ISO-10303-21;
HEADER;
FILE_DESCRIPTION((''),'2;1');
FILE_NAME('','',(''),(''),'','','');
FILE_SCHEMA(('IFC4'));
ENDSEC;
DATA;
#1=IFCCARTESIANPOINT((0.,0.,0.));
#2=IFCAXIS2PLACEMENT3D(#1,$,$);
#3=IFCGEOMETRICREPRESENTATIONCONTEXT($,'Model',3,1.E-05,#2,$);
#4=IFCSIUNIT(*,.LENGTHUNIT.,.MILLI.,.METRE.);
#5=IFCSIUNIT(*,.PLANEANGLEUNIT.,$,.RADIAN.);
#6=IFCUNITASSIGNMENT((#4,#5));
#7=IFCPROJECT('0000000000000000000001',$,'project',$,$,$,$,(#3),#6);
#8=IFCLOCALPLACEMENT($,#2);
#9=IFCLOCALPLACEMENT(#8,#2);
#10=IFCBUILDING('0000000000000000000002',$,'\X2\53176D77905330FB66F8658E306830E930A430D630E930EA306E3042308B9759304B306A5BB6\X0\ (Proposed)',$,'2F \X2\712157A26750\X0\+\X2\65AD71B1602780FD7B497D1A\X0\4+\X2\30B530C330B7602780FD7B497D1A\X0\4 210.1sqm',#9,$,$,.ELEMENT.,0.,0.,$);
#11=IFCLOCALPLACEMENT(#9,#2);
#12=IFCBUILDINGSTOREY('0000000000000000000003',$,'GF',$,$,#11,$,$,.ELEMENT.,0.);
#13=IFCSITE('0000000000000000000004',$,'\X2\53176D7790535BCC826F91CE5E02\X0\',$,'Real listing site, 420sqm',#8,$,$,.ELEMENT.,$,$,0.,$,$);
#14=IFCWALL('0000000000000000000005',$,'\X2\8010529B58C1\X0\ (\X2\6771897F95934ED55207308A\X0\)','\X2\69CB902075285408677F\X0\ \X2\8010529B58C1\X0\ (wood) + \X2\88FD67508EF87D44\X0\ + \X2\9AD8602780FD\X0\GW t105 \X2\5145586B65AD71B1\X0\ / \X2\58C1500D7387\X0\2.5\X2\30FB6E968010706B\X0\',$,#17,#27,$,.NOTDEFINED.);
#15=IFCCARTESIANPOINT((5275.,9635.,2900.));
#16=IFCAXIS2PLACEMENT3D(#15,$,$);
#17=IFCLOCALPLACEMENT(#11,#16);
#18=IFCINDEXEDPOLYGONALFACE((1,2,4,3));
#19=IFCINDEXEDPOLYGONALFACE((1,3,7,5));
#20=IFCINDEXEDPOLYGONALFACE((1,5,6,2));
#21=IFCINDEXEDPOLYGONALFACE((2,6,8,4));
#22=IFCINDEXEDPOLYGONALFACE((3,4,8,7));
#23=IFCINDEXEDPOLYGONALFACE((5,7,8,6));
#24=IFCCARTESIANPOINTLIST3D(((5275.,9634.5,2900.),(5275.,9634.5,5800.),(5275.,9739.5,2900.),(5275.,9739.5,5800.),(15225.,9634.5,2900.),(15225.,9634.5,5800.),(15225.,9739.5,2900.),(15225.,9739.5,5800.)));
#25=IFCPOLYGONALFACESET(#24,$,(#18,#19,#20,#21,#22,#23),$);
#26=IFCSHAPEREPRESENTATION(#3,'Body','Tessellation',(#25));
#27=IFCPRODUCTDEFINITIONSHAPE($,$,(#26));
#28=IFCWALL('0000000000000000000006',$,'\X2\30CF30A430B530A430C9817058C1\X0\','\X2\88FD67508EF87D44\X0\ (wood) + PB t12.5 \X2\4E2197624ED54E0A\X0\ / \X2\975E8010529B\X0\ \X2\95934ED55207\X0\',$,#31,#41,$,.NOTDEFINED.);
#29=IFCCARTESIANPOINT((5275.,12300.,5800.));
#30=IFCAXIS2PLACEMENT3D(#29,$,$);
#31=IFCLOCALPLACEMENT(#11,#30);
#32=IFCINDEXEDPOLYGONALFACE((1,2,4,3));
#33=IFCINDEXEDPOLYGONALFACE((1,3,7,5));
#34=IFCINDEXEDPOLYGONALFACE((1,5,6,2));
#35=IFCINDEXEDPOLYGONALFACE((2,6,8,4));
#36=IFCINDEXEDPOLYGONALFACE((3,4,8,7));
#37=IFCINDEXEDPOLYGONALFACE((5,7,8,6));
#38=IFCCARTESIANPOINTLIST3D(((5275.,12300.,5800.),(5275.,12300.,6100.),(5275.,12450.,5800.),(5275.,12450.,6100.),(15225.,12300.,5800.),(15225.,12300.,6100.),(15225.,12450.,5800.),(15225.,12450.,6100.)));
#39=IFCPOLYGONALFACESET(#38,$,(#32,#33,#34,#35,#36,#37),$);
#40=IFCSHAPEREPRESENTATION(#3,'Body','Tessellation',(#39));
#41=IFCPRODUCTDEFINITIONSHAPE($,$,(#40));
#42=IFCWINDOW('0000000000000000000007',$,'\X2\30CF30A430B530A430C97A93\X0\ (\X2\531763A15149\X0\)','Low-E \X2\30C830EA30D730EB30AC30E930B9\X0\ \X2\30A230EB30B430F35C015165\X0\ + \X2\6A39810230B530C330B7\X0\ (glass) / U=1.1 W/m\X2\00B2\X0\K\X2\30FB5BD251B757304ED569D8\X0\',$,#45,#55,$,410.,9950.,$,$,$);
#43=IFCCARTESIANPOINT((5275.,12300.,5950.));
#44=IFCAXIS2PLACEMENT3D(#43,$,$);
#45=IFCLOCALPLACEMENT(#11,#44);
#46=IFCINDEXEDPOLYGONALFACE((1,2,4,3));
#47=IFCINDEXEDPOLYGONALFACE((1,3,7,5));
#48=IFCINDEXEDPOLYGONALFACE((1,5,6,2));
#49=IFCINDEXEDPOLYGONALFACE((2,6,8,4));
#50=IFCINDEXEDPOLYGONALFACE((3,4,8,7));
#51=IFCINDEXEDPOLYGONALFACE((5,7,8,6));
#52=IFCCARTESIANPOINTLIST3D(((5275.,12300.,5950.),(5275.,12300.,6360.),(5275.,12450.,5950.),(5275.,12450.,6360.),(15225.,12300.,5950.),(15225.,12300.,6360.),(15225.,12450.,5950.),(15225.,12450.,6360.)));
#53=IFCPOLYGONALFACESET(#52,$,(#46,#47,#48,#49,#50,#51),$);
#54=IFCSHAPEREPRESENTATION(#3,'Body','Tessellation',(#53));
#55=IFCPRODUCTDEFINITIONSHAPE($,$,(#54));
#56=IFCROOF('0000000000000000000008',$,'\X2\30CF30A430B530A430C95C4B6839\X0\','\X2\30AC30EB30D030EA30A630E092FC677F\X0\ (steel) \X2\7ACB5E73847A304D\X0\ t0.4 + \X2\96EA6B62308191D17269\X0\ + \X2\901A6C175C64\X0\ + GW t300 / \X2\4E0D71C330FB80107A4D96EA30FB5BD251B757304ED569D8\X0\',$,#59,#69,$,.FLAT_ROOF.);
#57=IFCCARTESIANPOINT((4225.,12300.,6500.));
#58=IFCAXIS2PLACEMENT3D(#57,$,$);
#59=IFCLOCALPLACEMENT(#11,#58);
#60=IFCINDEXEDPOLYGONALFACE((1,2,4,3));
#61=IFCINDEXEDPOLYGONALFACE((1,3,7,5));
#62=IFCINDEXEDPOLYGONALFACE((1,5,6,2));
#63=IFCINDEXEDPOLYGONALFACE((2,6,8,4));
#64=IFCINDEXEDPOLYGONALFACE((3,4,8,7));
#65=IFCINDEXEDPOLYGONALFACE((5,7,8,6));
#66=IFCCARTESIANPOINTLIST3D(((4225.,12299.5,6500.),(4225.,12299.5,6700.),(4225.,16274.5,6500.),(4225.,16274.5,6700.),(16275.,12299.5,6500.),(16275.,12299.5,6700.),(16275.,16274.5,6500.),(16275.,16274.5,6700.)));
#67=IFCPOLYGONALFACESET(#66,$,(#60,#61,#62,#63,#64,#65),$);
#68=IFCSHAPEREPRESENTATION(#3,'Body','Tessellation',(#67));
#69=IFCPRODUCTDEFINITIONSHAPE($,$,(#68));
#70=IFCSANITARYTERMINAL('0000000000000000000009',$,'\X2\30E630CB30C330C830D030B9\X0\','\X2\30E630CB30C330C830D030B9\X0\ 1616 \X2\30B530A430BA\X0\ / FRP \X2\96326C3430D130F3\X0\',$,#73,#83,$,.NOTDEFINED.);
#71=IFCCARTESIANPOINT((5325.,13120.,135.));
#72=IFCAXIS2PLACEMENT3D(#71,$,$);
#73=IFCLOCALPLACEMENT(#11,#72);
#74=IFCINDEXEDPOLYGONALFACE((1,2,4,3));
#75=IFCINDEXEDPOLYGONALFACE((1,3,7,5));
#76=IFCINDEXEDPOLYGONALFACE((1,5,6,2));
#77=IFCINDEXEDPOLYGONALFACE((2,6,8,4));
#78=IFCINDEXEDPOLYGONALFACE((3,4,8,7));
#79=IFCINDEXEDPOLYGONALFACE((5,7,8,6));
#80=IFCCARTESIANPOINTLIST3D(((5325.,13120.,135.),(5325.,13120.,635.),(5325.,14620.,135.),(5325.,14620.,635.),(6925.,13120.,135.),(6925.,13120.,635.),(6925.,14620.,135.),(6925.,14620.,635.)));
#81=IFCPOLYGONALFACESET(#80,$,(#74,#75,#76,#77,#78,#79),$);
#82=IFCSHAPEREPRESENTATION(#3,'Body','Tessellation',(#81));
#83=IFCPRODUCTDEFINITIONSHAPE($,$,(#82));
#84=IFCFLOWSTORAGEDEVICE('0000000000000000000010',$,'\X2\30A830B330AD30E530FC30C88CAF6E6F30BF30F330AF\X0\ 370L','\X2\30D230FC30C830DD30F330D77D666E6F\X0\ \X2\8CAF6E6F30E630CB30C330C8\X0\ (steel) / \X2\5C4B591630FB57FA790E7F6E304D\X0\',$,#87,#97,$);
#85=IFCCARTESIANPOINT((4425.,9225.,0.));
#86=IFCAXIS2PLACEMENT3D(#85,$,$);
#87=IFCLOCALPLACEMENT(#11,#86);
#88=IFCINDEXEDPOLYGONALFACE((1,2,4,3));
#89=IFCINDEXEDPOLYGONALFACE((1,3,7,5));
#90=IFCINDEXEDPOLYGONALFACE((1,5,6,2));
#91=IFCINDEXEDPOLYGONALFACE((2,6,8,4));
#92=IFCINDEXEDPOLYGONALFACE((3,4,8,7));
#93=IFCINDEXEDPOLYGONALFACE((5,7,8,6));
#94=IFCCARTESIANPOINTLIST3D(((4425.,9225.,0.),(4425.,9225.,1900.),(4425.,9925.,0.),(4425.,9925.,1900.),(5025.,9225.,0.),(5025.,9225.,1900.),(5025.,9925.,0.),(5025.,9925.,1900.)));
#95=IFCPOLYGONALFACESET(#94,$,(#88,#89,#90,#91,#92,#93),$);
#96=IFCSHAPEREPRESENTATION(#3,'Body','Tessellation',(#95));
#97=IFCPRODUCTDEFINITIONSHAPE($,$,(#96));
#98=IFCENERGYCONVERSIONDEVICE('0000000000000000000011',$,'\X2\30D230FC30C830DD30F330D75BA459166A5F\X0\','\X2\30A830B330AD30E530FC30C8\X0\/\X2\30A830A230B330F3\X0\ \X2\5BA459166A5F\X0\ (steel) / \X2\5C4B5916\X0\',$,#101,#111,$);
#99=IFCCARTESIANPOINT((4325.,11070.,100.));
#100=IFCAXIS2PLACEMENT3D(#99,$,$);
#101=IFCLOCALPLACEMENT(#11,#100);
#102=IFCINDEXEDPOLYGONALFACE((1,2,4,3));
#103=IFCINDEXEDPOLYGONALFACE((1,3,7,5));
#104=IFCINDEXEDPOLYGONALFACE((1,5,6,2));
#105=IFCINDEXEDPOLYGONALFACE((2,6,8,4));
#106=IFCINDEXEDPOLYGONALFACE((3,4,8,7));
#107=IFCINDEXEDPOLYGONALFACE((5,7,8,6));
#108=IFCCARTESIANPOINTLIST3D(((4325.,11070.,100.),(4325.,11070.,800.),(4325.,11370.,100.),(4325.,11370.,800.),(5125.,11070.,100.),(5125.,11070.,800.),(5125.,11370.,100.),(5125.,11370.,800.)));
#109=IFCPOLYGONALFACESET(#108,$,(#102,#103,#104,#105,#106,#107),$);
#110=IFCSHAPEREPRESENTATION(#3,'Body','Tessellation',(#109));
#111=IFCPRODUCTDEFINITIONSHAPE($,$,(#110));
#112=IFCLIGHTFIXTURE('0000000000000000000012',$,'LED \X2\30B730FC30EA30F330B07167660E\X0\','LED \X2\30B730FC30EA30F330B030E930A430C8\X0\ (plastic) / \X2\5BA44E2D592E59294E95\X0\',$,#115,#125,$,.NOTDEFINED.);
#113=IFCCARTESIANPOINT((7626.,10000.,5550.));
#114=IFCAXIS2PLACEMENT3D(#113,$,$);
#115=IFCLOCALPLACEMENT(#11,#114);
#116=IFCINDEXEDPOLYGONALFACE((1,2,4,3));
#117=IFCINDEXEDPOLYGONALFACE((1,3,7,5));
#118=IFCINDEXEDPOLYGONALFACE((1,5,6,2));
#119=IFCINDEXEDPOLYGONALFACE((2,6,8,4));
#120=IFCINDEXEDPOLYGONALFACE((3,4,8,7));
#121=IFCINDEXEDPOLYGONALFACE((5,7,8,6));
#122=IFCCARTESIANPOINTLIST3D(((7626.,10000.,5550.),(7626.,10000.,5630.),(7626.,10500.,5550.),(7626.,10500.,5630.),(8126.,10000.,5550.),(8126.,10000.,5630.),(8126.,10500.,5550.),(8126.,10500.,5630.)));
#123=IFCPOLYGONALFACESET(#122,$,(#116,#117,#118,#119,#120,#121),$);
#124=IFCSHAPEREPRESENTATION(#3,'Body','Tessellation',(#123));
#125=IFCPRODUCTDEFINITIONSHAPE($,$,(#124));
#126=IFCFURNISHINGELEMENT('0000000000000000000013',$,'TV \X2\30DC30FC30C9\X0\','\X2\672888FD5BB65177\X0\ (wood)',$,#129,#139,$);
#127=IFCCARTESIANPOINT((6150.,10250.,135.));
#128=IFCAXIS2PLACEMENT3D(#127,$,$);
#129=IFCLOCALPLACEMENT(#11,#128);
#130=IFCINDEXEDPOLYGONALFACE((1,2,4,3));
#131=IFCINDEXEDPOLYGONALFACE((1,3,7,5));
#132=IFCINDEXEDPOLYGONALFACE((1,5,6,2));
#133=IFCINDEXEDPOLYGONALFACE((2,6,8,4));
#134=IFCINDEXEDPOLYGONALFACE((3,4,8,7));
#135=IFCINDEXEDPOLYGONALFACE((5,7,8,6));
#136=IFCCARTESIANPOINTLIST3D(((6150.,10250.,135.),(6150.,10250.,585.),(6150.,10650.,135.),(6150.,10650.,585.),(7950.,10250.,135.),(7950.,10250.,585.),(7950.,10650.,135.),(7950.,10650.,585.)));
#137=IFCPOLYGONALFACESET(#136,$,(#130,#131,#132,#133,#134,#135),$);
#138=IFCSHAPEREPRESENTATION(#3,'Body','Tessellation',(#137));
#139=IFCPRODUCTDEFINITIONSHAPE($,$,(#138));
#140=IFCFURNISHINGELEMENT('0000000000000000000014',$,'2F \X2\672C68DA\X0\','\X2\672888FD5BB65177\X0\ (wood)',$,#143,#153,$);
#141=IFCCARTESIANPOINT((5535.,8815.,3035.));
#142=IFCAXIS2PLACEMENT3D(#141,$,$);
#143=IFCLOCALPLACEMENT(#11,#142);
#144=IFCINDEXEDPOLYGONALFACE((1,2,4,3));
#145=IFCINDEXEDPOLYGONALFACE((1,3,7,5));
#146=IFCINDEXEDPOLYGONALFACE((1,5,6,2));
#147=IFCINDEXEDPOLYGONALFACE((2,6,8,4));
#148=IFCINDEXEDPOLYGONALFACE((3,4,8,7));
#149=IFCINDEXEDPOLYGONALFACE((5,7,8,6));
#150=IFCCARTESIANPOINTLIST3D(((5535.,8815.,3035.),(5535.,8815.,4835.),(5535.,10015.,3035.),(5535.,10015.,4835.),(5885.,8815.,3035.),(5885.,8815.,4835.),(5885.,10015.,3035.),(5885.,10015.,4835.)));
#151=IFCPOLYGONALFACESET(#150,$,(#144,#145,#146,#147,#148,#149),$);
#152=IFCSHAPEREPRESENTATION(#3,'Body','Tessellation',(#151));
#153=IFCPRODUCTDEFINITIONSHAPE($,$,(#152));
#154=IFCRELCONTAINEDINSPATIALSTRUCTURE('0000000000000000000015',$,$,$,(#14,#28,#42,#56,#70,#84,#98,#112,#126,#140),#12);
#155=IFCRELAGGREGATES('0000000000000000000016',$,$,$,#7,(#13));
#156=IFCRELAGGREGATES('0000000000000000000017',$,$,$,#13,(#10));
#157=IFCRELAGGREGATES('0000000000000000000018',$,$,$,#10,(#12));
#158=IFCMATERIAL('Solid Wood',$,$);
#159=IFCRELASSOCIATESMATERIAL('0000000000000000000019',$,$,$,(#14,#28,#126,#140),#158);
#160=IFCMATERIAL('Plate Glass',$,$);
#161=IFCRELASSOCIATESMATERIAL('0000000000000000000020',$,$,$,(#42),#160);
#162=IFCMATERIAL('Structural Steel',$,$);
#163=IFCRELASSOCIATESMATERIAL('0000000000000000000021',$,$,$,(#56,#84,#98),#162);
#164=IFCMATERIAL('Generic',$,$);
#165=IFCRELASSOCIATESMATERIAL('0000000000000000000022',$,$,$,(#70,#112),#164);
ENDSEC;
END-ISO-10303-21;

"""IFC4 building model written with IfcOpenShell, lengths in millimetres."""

from ifc_helpers import new_model, si_unit, frame, frame_2d, origin, place, context, project, spatial, rectangle, extrude, material, element, fill, save


model = new_model("IFC4")

# Units and contexts
model_context = context("Model", 3, precision=1e-05, world=origin())
ifc_project = project(units=[si_unit("LENGTHUNIT", "METRE", prefix="MILLI"), si_unit("PLANEANGLEUNIT", "RADIAN")], contexts=[model_context])

# Site, building, storey
site_placement = place(None, origin())
site = spatial("IfcSite", under=ifc_project, at=site_placement, Name="北海道富良野市", ObjectType="Real listing site, 420sqm", CompositionType="ELEMENT", RefElevation=0.0)
building_placement = place(site_placement, origin())
building = spatial("IfcBuilding", under=site, at=building_placement, Name="北海道・書斎とライブラリのある静かな家 (Proposed)", ObjectType="2F 無垢材+断熱性能等級4+サッシ性能等級4 210.1sqm", CompositionType="ELEMENT", ElevationOfRefHeight=0.0, ElevationOfTerrain=0.0)
storey_placement = place(building_placement, origin())
storey = spatial("IfcBuildingStorey", under=building, at=storey_placement, Name="GF", CompositionType="ELEMENT", Elevation=0.0)

# Shared definitions
ifc_material_1 = material(Name="Solid Wood")

# Wall
wall_1_placement = place(storey_placement, frame((5275.0, 9635.0, 2900.0)))
element("IfcWall", 1, at=wall_1_placement, inside=storey, material=ifc_material_1, Name="耐力壁 (東西間仕切り)", Description="構造用合板 耐力壁 (wood) + 製材軸組 + 高性能GW t105 充填断熱 / 壁倍率2.5・準耐火", PredefinedType="NOTDEFINED", context=model_context, shape_type="SweptSolid", body=[
    extrude(rectangle(XDim=9950.0, YDim=105.0, at=frame_2d((4975.0, 52.0))), frame((5275.0, 9635.0, 2900.0)), (0.0, 0.0, 1.0), 2900.0),
])

# Wall, opening, window
wall_2_placement = place(storey_placement, frame((5275.0, 12300.0, 5800.0)))
wall_2 = element("IfcWall", 2, at=wall_2_placement, inside=storey, material=ifc_material_1, Name="ハイサイド腰壁", Description="製材軸組 (wood) + PB t12.5 両面仕上 / 非耐力 間仕切", PredefinedType="NOTDEFINED", context=model_context, shape_type="SweptSolid", body=[
    extrude(rectangle(XDim=9950.0, YDim=150.0, at=frame_2d((4975.0, 75.0))), frame((5275.0, 12300.0, 5800.0)), (0.0, 0.0, 1.0), 700.0),
])
opening_1_placement = place(storey_placement, frame((5275.0, 12300.0, 5950.0)))
opening_1 = element("IfcOpeningElement", 3, at=opening_1_placement, cuts=wall_2, PredefinedType="NOTDEFINED", context=model_context, shape_type="SweptSolid", body=[
    extrude(rectangle(XDim=9950.0, YDim=150.0, at=frame_2d((4975.0, 75.0))), frame((5275.0, 12300.0, 5950.0)), (0.0, 0.0, 1.0), 410.0),
])
ifc_material_2 = material(Name="Plate Glass")
window_placement = place(storey_placement, frame((5275.0, 12300.0, 5950.0)))
window = element("IfcWindow", 4, at=window_placement, inside=storey, material=ifc_material_2, Name="ハイサイド窓 (北採光)", Description="Low-E トリプルガラス アルゴン封入 + 樹脂サッシ (glass) / U=1.1 W/m²K・寒冷地仕様", OverallHeight=410.0, OverallWidth=9950.0, context=model_context, shape_type="SweptSolid", body=[
    extrude(rectangle(XDim=9950.0, YDim=150.0, at=frame_2d((4975.0, 75.0))), frame((5275.0, 12300.0, 5950.0)), (0.0, 0.0, 1.0), 410.0),
])
fill(opening_1, window)

# Roof
ifc_material_3 = material(Name="Structural Steel")
roof_placement = place(storey_placement, frame((4225.0, 12300.0, 6500.0)))
element("IfcRoof", 5, at=roof_placement, inside=storey, material=ifc_material_3, Name="ハイサイド屋根", Description="ガルバリウム鋼板 (steel) 立平葺き t0.4 + 雪止め金物 + 通気層 + GW t300 / 不燃・耐積雪・寒冷地仕様", PredefinedType="FLAT_ROOF", context=model_context, shape_type="SweptSolid", body=[
    extrude(rectangle(XDim=12050.0, YDim=3975.0, at=frame_2d((6025.0, 1987.0))), frame((4225.0, 12300.0, 6500.0)), (0.0, 0.0, 1.0), 200.0),
])

# Sanitary terminal
ifc_material_4 = material(Name="Generic")
sanitary_terminal_placement = place(storey_placement, frame((5325.0, 13120.0, 135.0)))
element("IfcSanitaryTerminal", 6, at=sanitary_terminal_placement, inside=storey, material=ifc_material_4, Name="ユニットバス", Description="ユニットバス 1616 サイズ / FRP 防水パン", PredefinedType="NOTDEFINED", context=model_context, shape_type="SweptSolid", body=[
    extrude(rectangle(XDim=1600.0, YDim=1500.0, at=frame_2d((800.0, 750.0))), frame((5325.0, 13120.0, 135.0)), (0.0, 0.0, 1.0), 500.0),
])

# Flow storage device
flow_storage_device_placement = place(storey_placement, frame((4425.0, 9225.0, 0.0)))
element("IfcFlowStorageDevice", 7, at=flow_storage_device_placement, inside=storey, material=ifc_material_3, Name="エコキュート貯湯タンク 370L", Description="ヒートポンプ給湯 貯湯ユニット (steel) / 屋外・基礎置き", context=model_context, shape_type="SweptSolid", body=[
    extrude(rectangle(XDim=600.0, YDim=700.0, at=frame_2d((300.0, 350.0))), frame((4425.0, 9225.0, 0.0)), (0.0, 0.0, 1.0), 1900.0),
])

# Energy conversion device
energy_conversion_device_placement = place(storey_placement, frame((4325.0, 11070.0, 100.0)))
element("IfcEnergyConversionDevice", 8, at=energy_conversion_device_placement, inside=storey, material=ifc_material_3, Name="ヒートポンプ室外機", Description="エコキュート/エアコン 室外機 (steel) / 屋外", context=model_context, shape_type="SweptSolid", body=[
    extrude(rectangle(XDim=800.0, YDim=300.0, at=frame_2d((400.0, 150.0))), frame((4325.0, 11070.0, 100.0)), (0.0, 0.0, 1.0), 700.0),
])

# Light fixture
light_fixture_placement = place(storey_placement, frame((7626.0, 10000.0, 5550.0)))
element("IfcLightFixture", 9, at=light_fixture_placement, inside=storey, material=ifc_material_4, Name="LED シーリング照明", Description="LED シーリングライト (plastic) / 室中央天井", PredefinedType="NOTDEFINED", context=model_context, shape_type="SweptSolid", body=[
    extrude(rectangle(XDim=500.0, YDim=500.0, at=frame_2d((250.0, 250.0))), frame((7626.0, 10000.0, 5550.0)), (0.0, 0.0, 1.0), 80.0),
])

# Furnishing elements
furnishing_1_placement = place(storey_placement, frame((6150.0, 10250.0, 135.0)))
element("IfcFurnishingElement", 10, at=furnishing_1_placement, inside=storey, material=ifc_material_1, Name="TV ボード", Description="木製家具 (wood)", context=model_context, shape_type="SweptSolid", body=[
    extrude(rectangle(XDim=1800.0, YDim=400.0, at=frame_2d((900.0, 200.0))), frame((6150.0, 10250.0, 135.0)), (0.0, 0.0, 1.0), 450.0),
])
furnishing_2_placement = place(storey_placement, frame((5535.0, 8815.0, 3035.0)))
element("IfcFurnishingElement", 11, at=furnishing_2_placement, inside=storey, material=ifc_material_1, Name="2F 本棚", Description="木製家具 (wood)", context=model_context, shape_type="SweptSolid", body=[
    extrude(rectangle(XDim=350.0, YDim=1200.0, at=frame_2d((175.0, 600.0))), frame((5535.0, 8815.0, 3035.0)), (0.0, 0.0, 1.0), 1800.0),
])

save(model, "model.ifc")
